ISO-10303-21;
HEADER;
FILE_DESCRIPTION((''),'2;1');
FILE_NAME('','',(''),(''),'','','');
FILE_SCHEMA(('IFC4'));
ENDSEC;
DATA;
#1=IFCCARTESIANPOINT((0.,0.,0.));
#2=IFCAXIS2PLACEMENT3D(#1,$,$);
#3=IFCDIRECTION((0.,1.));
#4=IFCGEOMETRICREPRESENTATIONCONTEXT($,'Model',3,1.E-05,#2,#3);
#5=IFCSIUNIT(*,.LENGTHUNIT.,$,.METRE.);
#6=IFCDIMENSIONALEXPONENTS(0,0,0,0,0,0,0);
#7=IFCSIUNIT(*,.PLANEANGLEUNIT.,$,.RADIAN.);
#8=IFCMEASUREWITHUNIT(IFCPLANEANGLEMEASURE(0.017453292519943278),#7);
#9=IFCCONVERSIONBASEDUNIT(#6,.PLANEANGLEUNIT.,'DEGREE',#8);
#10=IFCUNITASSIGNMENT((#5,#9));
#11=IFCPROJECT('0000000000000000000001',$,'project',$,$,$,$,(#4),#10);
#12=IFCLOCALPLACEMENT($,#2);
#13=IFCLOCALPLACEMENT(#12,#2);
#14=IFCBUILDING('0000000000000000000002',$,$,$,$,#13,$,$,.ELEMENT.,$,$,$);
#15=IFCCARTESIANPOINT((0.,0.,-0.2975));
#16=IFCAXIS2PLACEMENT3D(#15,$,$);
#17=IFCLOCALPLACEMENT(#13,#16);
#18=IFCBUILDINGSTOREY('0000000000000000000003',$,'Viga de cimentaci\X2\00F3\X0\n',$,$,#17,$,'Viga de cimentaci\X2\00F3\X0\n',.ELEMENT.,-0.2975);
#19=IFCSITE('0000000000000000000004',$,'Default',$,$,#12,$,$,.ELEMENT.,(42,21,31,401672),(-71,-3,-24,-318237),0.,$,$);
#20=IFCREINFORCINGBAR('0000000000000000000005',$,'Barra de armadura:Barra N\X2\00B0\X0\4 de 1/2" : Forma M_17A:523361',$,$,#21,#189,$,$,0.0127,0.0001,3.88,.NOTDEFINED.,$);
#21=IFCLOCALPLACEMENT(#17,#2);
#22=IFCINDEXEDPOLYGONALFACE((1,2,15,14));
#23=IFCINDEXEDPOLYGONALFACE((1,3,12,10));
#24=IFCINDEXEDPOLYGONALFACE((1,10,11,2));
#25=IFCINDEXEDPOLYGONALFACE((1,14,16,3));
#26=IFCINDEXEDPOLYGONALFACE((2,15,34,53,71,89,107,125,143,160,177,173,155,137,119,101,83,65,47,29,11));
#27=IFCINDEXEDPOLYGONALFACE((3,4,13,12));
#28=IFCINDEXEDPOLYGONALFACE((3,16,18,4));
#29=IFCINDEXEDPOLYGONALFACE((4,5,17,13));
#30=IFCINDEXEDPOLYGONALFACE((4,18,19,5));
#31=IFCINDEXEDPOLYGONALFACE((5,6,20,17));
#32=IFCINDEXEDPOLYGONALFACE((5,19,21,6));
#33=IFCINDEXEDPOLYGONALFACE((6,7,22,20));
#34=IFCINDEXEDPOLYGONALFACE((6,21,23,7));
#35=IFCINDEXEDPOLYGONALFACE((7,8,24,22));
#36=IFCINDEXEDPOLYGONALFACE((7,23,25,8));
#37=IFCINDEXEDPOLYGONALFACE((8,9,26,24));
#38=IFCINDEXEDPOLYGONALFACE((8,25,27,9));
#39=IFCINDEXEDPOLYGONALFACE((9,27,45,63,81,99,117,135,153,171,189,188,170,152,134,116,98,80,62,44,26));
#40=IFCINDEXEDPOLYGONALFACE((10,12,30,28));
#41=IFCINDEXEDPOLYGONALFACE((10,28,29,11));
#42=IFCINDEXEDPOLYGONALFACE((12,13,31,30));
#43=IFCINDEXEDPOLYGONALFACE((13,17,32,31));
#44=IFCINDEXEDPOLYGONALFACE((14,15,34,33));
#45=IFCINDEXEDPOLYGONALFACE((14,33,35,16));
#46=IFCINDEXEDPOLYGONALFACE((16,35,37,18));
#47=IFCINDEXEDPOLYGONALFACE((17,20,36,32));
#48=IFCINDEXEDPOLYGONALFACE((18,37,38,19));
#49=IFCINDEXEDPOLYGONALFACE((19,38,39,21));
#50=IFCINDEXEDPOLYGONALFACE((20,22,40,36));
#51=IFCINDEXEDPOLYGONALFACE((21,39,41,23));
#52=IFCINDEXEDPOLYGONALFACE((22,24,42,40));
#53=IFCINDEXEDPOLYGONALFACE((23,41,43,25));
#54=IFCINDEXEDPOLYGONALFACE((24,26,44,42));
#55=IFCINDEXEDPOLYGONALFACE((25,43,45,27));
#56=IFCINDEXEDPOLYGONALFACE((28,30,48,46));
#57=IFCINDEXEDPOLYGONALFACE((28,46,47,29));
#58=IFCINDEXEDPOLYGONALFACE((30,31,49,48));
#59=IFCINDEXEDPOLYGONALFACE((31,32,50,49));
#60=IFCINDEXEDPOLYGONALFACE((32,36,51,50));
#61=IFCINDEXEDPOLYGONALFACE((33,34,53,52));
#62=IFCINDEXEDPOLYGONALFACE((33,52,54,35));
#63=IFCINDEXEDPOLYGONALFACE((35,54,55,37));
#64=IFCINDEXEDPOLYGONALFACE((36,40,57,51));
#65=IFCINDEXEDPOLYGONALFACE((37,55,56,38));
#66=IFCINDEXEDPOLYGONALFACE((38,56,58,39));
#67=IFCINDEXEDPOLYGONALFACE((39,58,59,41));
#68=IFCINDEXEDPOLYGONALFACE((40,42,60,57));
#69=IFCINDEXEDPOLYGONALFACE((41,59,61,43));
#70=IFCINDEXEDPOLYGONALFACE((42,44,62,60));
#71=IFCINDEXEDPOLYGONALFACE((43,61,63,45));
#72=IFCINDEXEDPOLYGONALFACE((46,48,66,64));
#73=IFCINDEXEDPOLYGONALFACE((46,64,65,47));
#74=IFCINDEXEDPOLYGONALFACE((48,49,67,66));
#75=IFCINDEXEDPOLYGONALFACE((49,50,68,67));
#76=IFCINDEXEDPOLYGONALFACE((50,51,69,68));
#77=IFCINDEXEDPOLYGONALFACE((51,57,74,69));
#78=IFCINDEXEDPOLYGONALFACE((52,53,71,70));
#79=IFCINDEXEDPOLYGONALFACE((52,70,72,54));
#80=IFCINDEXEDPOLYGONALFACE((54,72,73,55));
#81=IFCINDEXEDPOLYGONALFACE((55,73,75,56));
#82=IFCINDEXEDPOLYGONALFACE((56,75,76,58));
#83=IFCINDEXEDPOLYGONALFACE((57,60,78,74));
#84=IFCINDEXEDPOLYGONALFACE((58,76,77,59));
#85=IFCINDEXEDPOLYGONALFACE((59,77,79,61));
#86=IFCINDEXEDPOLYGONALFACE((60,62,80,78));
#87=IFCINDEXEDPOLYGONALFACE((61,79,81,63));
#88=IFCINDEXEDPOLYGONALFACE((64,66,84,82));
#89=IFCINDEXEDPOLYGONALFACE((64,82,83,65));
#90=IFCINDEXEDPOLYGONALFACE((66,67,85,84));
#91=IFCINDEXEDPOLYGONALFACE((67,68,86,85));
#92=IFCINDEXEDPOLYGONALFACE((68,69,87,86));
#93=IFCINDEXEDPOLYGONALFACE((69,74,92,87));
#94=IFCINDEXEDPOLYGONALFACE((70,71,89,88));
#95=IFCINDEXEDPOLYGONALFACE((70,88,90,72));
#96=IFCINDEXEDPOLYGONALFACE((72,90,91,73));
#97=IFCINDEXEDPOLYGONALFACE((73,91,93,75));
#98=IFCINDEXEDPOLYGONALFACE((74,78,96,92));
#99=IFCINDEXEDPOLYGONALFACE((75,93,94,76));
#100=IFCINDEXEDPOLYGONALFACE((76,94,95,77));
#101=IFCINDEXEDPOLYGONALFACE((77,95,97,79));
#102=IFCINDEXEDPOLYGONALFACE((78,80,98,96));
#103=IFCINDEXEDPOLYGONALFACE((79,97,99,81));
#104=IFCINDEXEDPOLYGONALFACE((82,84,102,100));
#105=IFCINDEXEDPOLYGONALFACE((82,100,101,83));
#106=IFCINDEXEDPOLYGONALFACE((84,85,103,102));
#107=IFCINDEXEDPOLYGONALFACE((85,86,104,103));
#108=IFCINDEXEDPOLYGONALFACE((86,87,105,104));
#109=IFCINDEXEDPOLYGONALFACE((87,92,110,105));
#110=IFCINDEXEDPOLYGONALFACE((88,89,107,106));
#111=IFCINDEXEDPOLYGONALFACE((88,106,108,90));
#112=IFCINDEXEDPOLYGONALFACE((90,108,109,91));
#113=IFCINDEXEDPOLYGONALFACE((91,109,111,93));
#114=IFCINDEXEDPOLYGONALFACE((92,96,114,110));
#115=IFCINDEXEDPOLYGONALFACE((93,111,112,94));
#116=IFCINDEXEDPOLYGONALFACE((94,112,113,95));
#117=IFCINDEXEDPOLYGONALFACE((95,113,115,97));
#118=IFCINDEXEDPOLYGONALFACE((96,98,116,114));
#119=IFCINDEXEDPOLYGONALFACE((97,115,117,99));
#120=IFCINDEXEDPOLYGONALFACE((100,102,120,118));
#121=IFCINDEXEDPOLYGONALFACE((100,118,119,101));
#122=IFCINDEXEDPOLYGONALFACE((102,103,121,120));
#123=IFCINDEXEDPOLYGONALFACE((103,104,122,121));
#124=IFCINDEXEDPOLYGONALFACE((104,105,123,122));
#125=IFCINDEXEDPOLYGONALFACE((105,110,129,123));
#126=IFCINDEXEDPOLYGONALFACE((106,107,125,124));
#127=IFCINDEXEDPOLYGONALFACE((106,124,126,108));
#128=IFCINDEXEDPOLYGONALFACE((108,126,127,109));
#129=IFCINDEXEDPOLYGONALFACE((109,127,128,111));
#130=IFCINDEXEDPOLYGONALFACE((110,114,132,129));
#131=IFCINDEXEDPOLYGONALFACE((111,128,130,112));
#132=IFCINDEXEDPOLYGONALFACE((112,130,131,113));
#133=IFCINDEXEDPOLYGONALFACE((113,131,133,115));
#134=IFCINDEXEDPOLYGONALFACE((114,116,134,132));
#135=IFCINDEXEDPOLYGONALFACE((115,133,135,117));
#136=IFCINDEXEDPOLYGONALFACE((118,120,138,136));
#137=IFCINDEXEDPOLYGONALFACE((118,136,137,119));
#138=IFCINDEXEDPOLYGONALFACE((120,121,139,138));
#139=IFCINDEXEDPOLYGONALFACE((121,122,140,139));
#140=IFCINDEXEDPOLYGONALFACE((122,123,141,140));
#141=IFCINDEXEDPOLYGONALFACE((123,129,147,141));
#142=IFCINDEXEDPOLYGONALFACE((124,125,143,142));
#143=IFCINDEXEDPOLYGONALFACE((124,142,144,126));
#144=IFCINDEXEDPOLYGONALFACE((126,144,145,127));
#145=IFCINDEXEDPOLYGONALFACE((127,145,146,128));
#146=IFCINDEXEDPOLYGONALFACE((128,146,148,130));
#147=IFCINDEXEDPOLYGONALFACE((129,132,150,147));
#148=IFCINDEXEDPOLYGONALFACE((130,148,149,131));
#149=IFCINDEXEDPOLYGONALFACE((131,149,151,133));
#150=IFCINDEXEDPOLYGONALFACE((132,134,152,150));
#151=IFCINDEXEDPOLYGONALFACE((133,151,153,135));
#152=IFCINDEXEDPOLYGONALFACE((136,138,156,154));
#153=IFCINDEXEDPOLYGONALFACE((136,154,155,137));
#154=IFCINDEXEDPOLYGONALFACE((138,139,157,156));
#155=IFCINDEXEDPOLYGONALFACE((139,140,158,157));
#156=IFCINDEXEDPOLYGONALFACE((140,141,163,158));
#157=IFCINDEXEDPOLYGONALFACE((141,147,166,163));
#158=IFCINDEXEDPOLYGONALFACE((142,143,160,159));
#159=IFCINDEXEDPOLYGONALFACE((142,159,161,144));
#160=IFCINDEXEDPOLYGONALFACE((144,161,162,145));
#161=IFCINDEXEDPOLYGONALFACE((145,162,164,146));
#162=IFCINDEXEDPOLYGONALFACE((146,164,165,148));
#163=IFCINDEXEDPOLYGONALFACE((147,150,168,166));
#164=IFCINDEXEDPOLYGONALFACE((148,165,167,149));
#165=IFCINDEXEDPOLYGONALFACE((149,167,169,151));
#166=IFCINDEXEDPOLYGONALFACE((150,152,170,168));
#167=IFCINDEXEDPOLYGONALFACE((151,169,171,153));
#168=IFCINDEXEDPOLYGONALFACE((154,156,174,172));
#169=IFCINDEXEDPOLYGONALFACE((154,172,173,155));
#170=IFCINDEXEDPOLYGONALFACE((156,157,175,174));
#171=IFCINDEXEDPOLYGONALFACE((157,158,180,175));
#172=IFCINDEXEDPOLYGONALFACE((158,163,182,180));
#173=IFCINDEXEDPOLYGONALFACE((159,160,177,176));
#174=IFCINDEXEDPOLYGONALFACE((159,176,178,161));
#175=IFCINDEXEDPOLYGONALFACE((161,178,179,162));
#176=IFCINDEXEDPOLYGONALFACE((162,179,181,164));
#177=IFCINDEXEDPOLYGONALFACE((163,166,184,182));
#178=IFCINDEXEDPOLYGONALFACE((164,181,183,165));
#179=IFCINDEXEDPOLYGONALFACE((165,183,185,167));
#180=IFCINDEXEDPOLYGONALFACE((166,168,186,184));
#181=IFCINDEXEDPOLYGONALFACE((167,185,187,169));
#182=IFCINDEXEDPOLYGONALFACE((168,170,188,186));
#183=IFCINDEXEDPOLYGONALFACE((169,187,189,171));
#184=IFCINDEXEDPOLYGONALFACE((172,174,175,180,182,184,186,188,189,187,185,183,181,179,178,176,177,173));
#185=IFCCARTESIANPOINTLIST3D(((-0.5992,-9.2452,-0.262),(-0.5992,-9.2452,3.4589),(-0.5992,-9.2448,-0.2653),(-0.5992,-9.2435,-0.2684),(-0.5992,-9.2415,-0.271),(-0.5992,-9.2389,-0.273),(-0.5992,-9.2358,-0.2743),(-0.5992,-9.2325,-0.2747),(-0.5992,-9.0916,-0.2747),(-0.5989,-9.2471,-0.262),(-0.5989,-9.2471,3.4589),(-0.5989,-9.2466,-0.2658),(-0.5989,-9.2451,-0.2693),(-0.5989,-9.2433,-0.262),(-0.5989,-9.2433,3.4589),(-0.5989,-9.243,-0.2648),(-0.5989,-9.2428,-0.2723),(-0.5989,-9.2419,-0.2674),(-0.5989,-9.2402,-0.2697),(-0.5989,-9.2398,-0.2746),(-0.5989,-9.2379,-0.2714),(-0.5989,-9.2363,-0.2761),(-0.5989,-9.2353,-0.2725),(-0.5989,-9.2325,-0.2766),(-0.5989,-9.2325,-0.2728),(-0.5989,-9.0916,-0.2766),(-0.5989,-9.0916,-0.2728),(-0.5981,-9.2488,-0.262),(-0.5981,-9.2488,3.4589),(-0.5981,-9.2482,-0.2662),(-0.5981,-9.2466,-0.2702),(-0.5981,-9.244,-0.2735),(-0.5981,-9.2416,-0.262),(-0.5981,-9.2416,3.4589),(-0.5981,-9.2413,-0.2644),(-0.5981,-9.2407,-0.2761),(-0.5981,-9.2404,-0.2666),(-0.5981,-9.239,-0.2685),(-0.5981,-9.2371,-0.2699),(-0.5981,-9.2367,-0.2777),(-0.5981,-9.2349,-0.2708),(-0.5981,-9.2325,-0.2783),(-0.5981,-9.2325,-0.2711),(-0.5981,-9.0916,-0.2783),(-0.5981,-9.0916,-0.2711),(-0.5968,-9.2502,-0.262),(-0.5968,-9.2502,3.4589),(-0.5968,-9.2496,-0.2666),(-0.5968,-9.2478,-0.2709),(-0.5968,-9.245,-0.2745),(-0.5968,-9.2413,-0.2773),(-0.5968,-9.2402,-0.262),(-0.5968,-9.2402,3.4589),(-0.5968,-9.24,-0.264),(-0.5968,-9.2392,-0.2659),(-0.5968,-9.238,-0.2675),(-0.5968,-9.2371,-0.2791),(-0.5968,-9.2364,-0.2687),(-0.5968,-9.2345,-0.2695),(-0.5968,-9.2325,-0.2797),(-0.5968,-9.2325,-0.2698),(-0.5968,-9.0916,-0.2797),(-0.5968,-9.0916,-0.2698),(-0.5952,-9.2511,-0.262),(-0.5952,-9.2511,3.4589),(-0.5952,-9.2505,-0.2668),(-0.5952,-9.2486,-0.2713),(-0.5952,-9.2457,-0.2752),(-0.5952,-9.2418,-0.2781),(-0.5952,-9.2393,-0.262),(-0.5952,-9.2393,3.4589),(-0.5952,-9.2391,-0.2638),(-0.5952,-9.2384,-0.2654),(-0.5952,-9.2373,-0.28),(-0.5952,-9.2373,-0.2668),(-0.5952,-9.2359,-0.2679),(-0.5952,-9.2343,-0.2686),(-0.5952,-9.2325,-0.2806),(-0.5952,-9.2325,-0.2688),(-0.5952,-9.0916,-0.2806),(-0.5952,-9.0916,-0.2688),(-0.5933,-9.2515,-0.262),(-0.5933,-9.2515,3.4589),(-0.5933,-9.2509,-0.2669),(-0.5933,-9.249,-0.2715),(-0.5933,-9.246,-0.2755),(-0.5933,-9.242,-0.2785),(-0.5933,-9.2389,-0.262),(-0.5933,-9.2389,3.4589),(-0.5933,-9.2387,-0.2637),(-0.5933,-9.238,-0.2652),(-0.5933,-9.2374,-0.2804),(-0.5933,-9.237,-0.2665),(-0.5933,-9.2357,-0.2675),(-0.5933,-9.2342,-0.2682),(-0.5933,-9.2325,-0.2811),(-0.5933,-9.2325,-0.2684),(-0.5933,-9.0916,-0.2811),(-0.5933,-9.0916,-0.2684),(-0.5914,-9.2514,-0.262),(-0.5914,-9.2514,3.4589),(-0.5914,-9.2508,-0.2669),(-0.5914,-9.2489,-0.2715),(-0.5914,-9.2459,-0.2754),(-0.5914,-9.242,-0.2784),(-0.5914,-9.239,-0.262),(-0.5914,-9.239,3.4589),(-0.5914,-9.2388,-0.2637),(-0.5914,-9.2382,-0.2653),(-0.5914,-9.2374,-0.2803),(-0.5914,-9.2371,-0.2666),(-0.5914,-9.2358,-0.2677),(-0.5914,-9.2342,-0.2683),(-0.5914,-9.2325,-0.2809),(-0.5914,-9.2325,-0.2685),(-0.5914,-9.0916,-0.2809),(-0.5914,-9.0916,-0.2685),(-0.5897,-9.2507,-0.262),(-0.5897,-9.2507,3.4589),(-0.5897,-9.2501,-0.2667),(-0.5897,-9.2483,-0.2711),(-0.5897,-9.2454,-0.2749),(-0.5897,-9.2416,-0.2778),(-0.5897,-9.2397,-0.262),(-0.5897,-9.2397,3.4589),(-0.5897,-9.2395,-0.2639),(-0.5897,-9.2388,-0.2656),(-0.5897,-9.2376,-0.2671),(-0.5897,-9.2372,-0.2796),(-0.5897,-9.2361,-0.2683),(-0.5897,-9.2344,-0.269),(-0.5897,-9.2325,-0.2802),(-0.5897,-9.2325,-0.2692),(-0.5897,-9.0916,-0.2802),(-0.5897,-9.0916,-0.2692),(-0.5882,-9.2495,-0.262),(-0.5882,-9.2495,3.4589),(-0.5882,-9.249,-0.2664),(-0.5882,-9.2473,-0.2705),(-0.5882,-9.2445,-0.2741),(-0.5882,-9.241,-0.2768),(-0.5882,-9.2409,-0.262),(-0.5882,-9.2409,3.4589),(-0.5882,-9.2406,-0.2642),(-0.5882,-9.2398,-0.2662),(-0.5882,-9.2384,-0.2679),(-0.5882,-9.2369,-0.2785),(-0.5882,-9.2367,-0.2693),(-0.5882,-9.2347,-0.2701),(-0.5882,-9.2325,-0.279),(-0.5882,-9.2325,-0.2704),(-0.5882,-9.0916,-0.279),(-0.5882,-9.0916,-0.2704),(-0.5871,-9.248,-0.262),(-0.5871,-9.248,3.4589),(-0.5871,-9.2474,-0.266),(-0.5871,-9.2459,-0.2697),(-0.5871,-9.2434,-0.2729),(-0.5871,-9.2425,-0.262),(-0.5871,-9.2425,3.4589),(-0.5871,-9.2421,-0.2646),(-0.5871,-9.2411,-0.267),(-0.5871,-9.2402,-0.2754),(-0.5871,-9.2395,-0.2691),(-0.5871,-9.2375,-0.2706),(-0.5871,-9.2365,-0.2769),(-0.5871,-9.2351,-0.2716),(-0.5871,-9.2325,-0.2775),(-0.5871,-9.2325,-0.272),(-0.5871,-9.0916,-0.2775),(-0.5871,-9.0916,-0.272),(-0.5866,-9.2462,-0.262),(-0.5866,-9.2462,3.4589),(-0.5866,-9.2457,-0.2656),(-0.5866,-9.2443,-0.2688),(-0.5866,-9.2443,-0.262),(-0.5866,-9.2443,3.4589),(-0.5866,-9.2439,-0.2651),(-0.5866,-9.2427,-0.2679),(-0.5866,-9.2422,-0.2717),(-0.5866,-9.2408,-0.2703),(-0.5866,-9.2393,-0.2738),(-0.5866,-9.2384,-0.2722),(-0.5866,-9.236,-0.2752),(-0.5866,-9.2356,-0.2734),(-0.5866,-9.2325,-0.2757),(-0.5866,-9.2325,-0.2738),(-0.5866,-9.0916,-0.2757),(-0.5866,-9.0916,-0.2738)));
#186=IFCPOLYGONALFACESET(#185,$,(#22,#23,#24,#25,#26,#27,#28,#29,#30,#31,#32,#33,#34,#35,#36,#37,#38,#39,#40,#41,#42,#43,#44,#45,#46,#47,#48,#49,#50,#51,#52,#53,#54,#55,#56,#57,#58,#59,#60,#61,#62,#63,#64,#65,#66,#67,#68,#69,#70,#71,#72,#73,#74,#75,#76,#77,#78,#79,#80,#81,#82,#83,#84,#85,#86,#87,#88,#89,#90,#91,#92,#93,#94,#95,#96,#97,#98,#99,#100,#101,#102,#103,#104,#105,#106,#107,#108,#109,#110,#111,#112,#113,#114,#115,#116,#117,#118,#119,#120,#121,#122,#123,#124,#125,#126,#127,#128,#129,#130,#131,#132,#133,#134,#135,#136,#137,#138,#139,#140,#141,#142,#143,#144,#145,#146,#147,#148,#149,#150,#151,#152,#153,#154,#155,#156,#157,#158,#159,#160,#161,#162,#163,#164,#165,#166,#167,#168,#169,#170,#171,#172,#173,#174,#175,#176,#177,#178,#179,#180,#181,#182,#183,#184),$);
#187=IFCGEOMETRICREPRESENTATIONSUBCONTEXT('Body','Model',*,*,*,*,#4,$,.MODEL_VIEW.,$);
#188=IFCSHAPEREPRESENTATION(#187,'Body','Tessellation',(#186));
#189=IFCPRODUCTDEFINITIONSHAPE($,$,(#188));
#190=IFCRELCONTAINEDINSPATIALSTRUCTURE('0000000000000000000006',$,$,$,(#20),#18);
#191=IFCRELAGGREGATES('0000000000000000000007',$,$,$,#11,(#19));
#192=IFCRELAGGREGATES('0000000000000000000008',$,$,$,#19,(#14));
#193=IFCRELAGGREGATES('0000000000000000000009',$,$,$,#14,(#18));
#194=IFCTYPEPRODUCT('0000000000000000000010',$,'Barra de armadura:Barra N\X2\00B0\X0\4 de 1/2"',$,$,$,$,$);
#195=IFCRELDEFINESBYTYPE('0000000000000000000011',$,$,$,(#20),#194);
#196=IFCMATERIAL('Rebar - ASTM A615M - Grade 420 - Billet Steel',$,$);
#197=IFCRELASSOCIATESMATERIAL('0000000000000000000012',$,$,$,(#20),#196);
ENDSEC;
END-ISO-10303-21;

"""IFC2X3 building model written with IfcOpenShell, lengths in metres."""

from ifc_helpers import new_model, entity, si_unit, converted_unit, direction, frame, origin, place, context, subcontext, project, spatial, material, type_object, element, save


model = new_model("IFC2X3")

# Units and contexts
model_context = context("Model", 3, precision=1e-05, world=origin(), true_north=direction((0.0, 1.0)))
body_context = subcontext(model_context, "Body", "Model", "MODEL_VIEW")
ifc_project = project(units=[si_unit("LENGTHUNIT", "METRE"), converted_unit("PLANEANGLEUNIT", "DEGREE", entity("IfcPlaneAngleMeasure", 0.017453292519943278), si_unit("PLANEANGLEUNIT", "RADIAN"), dimensions=[0, 0, 0, 0, 0, 0, 0])], contexts=[model_context])

# Site, building, storey
site_placement = place(None, origin())
site = spatial("IfcSite", under=ifc_project, at=site_placement, Name="Default", CompositionType="ELEMENT", RefLatitude=(42, 21, 31, 401672), RefLongitude=(-71, -3, -24, -318237), RefElevation=0.0)
building_placement = place(site_placement, origin())
building = spatial("IfcBuilding", under=site, at=building_placement, CompositionType="ELEMENT")
storey_placement = place(building_placement, frame((0.0, 0.0, -0.2975)))
storey = spatial("IfcBuildingStorey", under=building, at=storey_placement, Name="Viga de cimentación", LongName="Viga de cimentación", CompositionType="ELEMENT", Elevation=-0.2975)

# Reinforcing bar
ifc_material = material(Name="Rebar - ASTM A615M - Grade 420 - Billet Steel")
type_product_1 = type_object("IfcTypeProduct", Name="Barra de armadura:Barra N°4 de 1/2\"")
reinforcing_bar_1_placement = place(storey_placement, origin())
element("IfcReinforcingBar", 1, at=reinforcing_bar_1_placement, inside=storey, type_object=type_product_1, material=ifc_material, Name="Barra de armadura:Barra N°4 de 1/2\" : Forma M_17A:523361", BarLength=3.88, BarRole="NOTDEFINED", CrossSectionArea=0.0001, NominalDiameter=0.0127, context=body_context, shape_type="AdvancedSweptSolid", body=[
    entity("IfcSweptDiskSolid", entity("IfcCompositeCurve", [entity("IfcCompositeCurveSegment", "CONTINUOUS", True, entity("IfcPolyline", [entity("IfcCartesianPoint", [-0.5929, -9.2452, 3.4589]), entity("IfcCartesianPoint", [-0.5929, -9.2452, -0.262])])), entity("IfcCompositeCurveSegment", "CONTINUOUS", True, entity("IfcTrimmedCurve", entity("IfcCircle", entity("IfcAxis2Placement3D", entity("IfcCartesianPoint", [-0.5929, -9.2325, -0.262]), entity("IfcDirection", [1.0, 0.0, 0.0]), entity("IfcDirection", [0.0, 0.0, -1.0])), 0.0127), [entity("IfcParameterValue", 270.0)], [entity("IfcParameterValue", 360.0)], True, "PARAMETER")), entity("IfcCompositeCurveSegment", "CONTINUOUS", True, entity("IfcPolyline", [entity("IfcCartesianPoint", [-0.5929, -9.2325, -0.2747]), entity("IfcCartesianPoint", [-0.5929, -9.0916, -0.2747])]))], False), 0.0063, None, 0.0, 92.0),
])

save(model, "model.ifc")
